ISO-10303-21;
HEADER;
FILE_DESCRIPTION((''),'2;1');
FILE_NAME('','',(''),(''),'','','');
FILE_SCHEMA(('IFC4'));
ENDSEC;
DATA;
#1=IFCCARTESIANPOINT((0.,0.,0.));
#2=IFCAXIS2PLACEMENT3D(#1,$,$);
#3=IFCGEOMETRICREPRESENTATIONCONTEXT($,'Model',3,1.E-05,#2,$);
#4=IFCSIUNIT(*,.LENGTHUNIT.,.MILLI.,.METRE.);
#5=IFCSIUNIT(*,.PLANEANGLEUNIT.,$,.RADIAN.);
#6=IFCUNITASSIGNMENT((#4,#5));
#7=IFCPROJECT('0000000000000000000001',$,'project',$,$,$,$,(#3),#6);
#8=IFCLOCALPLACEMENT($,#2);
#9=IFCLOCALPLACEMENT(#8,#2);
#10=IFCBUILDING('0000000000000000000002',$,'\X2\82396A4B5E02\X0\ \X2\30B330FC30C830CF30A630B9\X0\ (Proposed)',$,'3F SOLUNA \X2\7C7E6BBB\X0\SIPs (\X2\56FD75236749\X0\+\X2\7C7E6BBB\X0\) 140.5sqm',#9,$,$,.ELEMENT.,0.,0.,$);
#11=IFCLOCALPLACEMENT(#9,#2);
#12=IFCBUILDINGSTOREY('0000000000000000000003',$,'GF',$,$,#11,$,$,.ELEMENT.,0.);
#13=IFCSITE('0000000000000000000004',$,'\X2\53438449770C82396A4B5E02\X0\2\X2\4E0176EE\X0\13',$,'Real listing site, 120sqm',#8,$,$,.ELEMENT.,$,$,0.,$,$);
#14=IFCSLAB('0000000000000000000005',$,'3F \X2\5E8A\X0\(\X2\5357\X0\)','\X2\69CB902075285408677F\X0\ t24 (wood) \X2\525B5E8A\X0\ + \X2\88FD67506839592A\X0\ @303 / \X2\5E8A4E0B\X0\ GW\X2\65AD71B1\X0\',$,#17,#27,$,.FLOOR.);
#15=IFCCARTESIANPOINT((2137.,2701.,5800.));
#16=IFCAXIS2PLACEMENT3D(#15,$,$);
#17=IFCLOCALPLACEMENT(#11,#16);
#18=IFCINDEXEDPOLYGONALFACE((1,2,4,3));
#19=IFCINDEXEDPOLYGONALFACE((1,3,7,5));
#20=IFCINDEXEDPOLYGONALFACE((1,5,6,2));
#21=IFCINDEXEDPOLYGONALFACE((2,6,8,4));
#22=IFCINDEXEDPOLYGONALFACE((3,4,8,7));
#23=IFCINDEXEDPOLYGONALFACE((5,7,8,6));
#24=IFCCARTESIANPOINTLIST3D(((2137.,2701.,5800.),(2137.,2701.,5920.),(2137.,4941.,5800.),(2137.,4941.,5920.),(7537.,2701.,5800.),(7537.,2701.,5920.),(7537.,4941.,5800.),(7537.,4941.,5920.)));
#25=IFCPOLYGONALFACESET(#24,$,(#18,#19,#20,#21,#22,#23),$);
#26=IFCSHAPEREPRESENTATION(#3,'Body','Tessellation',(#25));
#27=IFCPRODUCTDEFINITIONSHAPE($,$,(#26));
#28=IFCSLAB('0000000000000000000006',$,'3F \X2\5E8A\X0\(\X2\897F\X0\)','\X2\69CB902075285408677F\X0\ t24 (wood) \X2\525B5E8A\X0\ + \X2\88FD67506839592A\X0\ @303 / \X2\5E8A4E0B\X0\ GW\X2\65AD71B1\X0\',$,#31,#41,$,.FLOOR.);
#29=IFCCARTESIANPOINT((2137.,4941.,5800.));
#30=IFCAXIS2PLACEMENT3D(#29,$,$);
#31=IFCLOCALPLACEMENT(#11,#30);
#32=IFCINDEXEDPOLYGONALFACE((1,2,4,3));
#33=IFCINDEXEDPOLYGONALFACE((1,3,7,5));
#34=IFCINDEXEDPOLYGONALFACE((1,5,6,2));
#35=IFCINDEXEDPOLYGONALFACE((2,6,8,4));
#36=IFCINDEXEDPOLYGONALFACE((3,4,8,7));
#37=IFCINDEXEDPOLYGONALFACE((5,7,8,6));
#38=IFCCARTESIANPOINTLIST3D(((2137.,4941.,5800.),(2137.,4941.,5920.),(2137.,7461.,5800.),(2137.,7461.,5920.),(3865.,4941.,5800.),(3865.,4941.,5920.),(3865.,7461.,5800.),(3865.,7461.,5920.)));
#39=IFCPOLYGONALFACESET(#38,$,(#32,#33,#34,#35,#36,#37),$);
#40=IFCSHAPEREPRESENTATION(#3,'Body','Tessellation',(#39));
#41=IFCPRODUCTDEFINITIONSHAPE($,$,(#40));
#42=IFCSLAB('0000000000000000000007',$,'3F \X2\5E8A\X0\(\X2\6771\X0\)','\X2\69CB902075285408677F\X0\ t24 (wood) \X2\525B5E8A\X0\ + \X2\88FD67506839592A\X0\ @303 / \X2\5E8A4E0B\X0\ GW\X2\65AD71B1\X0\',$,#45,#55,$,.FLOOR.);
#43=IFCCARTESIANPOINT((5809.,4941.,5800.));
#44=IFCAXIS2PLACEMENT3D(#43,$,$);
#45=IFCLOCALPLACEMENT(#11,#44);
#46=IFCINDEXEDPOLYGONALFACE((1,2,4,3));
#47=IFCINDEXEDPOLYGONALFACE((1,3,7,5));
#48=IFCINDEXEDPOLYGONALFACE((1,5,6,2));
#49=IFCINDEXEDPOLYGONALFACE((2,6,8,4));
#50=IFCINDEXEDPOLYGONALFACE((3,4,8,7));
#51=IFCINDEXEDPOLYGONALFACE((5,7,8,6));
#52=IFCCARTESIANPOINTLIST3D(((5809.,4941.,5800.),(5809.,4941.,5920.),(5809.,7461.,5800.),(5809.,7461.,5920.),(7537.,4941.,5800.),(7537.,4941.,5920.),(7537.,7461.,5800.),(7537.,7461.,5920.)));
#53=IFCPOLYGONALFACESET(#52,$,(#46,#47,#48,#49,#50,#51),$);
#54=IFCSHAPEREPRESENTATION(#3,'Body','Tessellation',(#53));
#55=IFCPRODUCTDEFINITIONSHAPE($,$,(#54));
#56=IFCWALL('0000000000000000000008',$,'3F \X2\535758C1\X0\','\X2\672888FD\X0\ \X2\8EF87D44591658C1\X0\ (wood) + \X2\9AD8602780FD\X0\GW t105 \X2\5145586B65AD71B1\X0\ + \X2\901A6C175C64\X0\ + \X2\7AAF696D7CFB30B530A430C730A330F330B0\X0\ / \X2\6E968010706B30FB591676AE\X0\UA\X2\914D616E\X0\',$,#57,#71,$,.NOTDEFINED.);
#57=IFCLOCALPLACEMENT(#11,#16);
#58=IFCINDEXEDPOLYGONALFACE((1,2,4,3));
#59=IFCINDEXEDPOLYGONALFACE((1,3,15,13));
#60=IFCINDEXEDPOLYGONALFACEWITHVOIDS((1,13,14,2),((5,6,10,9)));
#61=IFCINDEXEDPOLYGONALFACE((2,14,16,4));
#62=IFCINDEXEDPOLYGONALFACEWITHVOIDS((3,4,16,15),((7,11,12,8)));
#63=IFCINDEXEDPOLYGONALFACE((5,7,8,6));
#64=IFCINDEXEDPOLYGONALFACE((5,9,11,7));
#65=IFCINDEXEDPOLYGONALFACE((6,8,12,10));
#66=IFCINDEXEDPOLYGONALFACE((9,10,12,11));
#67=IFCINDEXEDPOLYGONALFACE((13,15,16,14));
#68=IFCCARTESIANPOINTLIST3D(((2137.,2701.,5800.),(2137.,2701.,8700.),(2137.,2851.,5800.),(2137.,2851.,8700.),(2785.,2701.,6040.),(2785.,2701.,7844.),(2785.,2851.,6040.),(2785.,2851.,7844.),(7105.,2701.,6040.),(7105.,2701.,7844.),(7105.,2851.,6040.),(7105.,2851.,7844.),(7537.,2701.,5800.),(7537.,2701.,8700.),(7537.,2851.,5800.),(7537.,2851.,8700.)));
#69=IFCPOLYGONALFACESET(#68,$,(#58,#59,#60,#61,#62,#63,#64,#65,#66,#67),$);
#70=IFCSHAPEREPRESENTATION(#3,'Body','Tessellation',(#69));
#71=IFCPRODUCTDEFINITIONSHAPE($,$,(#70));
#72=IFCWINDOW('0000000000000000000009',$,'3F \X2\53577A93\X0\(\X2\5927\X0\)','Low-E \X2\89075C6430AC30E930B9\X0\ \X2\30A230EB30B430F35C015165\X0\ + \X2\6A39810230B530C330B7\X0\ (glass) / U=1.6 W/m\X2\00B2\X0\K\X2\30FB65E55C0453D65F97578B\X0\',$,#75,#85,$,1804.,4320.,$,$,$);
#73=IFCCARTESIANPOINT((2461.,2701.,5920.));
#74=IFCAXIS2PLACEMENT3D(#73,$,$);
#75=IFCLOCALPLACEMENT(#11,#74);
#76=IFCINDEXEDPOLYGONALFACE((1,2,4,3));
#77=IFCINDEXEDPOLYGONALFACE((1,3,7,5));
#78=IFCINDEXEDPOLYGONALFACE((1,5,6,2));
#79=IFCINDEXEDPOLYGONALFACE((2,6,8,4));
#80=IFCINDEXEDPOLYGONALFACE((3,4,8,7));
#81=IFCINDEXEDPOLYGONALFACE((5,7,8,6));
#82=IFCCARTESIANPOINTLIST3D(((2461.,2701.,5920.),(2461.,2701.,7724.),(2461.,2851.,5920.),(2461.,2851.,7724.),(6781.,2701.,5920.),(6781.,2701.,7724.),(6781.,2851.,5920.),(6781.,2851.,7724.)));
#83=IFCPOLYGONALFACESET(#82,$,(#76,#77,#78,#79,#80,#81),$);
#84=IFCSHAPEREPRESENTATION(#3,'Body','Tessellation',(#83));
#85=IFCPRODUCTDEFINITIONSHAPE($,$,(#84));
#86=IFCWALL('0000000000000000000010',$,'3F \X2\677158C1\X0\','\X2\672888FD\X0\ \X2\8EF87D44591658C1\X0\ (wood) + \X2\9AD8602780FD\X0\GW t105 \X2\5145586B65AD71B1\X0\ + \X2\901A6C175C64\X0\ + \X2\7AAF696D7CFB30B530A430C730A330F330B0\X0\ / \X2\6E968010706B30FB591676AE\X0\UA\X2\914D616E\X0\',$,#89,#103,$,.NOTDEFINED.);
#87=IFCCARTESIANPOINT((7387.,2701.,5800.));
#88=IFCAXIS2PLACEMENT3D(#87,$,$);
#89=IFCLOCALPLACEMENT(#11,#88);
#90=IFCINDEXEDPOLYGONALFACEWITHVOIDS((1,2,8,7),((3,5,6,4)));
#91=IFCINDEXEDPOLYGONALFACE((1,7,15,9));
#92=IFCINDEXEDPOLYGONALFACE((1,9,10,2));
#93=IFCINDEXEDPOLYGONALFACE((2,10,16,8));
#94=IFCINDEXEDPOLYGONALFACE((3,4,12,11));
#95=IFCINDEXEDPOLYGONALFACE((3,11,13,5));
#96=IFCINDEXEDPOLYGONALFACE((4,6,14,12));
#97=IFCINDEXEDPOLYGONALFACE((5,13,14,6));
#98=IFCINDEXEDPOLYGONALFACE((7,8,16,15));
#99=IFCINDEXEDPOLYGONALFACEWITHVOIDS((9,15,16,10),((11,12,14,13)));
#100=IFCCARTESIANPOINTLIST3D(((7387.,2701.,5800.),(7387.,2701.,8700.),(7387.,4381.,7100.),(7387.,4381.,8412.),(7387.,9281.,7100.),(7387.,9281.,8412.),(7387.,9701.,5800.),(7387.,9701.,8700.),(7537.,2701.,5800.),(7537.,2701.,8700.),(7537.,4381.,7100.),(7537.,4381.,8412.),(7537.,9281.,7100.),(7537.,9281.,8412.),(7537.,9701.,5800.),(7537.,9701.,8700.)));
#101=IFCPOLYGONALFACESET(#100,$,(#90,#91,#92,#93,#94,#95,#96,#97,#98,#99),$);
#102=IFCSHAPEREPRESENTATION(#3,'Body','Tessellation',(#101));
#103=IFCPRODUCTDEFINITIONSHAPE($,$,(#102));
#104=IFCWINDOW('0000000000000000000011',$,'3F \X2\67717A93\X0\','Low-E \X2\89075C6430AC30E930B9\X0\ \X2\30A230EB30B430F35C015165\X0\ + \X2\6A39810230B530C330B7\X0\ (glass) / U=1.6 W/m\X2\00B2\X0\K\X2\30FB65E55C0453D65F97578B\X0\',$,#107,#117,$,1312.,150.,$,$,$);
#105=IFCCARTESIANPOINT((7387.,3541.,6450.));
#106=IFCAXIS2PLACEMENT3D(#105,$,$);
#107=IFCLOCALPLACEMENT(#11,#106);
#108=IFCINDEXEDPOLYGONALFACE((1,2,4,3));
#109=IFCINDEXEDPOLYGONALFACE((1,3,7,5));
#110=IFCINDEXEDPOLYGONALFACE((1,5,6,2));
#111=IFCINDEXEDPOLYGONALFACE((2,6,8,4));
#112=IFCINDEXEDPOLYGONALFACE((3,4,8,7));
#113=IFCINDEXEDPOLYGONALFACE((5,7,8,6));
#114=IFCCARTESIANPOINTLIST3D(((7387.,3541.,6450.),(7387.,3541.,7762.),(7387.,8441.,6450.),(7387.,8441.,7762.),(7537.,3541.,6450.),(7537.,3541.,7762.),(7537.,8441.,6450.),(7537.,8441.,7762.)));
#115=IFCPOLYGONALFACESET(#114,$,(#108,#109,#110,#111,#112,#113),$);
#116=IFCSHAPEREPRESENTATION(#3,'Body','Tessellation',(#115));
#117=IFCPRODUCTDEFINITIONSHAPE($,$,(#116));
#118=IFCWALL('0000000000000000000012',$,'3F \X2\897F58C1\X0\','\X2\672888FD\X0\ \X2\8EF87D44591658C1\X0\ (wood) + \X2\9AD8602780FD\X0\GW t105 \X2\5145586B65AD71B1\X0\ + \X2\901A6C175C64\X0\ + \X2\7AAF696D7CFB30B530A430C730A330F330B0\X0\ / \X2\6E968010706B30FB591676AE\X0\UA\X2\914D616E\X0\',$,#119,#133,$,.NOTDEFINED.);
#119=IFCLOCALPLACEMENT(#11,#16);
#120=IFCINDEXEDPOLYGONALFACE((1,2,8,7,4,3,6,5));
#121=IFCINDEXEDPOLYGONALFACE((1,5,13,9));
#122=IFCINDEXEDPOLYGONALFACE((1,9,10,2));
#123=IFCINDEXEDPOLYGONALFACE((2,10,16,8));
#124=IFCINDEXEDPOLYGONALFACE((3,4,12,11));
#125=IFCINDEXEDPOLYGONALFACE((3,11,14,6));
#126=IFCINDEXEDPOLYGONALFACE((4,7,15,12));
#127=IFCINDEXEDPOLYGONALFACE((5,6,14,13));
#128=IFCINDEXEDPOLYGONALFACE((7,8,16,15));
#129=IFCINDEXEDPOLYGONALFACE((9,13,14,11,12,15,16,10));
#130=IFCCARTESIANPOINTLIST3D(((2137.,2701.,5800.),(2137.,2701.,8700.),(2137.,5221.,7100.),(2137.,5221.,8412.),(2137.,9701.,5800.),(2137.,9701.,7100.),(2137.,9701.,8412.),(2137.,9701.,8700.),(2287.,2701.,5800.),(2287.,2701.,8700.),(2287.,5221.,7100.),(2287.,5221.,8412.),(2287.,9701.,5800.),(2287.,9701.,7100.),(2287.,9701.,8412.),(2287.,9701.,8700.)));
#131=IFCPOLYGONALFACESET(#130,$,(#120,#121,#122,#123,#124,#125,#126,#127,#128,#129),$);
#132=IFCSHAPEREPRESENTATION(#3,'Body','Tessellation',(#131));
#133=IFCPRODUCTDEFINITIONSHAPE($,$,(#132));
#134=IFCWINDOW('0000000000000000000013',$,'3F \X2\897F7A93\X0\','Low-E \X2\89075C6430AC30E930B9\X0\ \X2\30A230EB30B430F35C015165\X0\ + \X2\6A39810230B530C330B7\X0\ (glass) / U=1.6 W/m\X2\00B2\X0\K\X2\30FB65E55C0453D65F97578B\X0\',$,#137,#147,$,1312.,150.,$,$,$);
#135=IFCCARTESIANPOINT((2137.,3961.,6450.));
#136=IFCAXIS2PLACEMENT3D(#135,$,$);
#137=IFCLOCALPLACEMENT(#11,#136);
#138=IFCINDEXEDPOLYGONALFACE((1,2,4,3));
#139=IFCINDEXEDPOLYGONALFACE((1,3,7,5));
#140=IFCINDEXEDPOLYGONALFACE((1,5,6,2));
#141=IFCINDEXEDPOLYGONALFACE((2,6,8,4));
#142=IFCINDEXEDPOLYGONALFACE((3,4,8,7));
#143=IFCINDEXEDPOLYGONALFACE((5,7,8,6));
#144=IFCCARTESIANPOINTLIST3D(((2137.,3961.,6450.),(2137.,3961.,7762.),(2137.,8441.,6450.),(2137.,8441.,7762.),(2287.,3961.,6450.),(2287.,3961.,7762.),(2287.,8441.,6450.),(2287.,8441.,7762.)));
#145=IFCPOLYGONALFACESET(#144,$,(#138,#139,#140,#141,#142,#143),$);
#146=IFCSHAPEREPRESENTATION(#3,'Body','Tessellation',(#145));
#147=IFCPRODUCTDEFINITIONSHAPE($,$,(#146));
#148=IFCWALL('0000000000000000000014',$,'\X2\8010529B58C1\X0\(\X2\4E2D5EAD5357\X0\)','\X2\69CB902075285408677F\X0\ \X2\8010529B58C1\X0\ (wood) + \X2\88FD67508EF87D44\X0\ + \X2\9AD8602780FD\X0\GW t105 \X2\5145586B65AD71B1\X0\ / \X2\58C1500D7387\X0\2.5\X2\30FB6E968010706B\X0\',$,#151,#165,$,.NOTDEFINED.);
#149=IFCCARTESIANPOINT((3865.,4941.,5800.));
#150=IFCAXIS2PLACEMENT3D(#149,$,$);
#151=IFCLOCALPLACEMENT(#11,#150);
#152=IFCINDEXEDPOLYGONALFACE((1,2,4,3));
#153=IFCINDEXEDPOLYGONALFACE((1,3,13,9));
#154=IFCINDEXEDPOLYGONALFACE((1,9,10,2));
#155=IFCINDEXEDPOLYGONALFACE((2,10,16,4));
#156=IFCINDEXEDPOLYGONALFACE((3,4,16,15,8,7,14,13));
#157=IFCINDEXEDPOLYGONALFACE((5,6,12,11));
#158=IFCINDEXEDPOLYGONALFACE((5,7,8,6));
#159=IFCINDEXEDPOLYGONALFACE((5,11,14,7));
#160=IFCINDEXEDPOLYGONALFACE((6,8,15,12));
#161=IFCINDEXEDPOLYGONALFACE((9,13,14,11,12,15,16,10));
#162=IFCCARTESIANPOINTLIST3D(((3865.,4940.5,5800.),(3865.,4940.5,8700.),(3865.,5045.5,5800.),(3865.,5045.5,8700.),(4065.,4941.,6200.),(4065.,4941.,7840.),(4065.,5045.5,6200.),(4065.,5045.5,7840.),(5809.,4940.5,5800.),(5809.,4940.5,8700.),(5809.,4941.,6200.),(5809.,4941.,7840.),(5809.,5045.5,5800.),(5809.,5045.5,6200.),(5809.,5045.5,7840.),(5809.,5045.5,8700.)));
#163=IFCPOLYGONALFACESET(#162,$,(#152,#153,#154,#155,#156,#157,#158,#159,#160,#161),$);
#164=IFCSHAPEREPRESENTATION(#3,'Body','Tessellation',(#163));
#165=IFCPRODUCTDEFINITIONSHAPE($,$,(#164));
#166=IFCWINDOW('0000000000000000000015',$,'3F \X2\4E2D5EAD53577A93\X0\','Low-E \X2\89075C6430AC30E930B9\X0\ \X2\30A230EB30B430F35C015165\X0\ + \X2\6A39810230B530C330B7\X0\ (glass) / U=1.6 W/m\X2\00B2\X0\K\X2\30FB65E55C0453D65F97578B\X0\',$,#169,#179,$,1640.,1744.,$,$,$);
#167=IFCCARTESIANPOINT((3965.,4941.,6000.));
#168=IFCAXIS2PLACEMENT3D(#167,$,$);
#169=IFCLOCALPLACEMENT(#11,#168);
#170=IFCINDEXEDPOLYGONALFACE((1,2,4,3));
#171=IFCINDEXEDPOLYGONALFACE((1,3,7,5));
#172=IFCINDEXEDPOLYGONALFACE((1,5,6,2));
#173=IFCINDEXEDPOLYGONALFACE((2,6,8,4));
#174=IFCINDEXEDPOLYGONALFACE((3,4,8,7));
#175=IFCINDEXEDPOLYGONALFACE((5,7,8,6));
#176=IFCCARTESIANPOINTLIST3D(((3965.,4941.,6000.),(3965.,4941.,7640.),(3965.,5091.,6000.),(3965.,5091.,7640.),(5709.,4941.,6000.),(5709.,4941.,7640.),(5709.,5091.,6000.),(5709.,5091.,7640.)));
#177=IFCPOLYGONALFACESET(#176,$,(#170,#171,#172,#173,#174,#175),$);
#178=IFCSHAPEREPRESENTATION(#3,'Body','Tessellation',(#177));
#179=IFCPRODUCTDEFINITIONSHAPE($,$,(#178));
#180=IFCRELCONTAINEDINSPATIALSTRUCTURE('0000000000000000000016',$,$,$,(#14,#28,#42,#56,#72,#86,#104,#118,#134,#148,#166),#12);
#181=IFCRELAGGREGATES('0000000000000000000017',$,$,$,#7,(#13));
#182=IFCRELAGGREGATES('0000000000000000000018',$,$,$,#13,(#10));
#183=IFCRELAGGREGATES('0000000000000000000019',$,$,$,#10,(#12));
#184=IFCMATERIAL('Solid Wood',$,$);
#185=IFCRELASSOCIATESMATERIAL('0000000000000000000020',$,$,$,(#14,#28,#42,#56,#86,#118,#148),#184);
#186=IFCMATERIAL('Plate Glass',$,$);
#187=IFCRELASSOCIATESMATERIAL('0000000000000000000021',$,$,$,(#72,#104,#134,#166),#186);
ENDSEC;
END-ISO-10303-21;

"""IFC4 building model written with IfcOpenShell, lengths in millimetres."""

from ifc_helpers import new_model, si_unit, frame, frame_2d, origin, place, context, project, spatial, rectangle, extrude, material, element, fill, save


model = new_model("IFC4")

# Units and contexts
model_context = context("Model", 3, precision=1e-05, world=origin())
ifc_project = project(units=[si_unit("LENGTHUNIT", "METRE", prefix="MILLI"), si_unit("PLANEANGLEUNIT", "RADIAN")], contexts=[model_context])

# Site, building, storey
site_placement = place(None, origin())
site = spatial("IfcSite", under=ifc_project, at=site_placement, Name="千葉県船橋市2丁目13", ObjectType="Real listing site, 120sqm", CompositionType="ELEMENT", RefElevation=0.0)
building_placement = place(site_placement, origin())
building = spatial("IfcBuilding", under=site, at=building_placement, Name="船橋市 コートハウス (Proposed)", ObjectType="3F SOLUNA 籾殻SIPs (国産杉+籾殻) 140.5sqm", CompositionType="ELEMENT", ElevationOfRefHeight=0.0, ElevationOfTerrain=0.0)
storey_placement = place(building_placement, origin())
storey = spatial("IfcBuildingStorey", under=building, at=storey_placement, Name="GF", CompositionType="ELEMENT", Elevation=0.0)

# Slabs
ifc_material_1 = material(Name="Solid Wood")
slab_1_placement = place(storey_placement, frame((2137.0, 2701.0, 5800.0)))
element("IfcSlab", 1, at=slab_1_placement, inside=storey, material=ifc_material_1, Name="3F 床(南)", Description="構造用合板 t24 (wood) 剛床 + 製材根太 @303 / 床下 GW断熱", PredefinedType="FLOOR", context=model_context, shape_type="SweptSolid", body=[
    extrude(rectangle(XDim=5400.0, YDim=2240.0, at=frame_2d((2700.0, 1120.0))), frame((2137.0, 2701.0, 5800.0)), (0.0, 0.0, 1.0), 120.0),
])
slab_2_placement = place(storey_placement, frame((2137.0, 4941.0, 5800.0)))
element("IfcSlab", 2, at=slab_2_placement, inside=storey, material=ifc_material_1, Name="3F 床(西)", Description="構造用合板 t24 (wood) 剛床 + 製材根太 @303 / 床下 GW断熱", PredefinedType="FLOOR", context=model_context, shape_type="SweptSolid", body=[
    extrude(rectangle(XDim=1728.0, YDim=2520.0, at=frame_2d((864.0, 1260.0))), frame((2137.0, 4941.0, 5800.0)), (0.0, 0.0, 1.0), 120.0),
])
slab_3_placement = place(storey_placement, frame((5809.0, 4941.0, 5800.0)))
element("IfcSlab", 3, at=slab_3_placement, inside=storey, material=ifc_material_1, Name="3F 床(東)", Description="構造用合板 t24 (wood) 剛床 + 製材根太 @303 / 床下 GW断熱", PredefinedType="FLOOR", context=model_context, shape_type="SweptSolid", body=[
    extrude(rectangle(XDim=1728.0, YDim=2520.0, at=frame_2d((864.0, 1260.0))), frame((5809.0, 4941.0, 5800.0)), (0.0, 0.0, 1.0), 120.0),
])

# Walls, openings, windows
wall_1_placement = place(storey_placement, frame((2137.0, 2701.0, 5800.0)))
wall_1 = element("IfcWall", 4, at=wall_1_placement, inside=storey, material=ifc_material_1, Name="3F 南壁", Description="木製 軸組外壁 (wood) + 高性能GW t105 充填断熱 + 通気層 + 窯業系サイディング / 準耐火・外皮UA配慮", PredefinedType="NOTDEFINED", context=model_context, shape_type="SweptSolid", body=[
    extrude(rectangle(XDim=5400.0, YDim=150.0, at=frame_2d((2700.0, 75.0))), frame((2137.0, 2701.0, 5800.0)), (0.0, 0.0, 1.0), 2900.0),
])
opening_1_placement = place(storey_placement, frame((2461.0, 2701.0, 5920.0)))
opening_1 = element("IfcOpeningElement", 5, at=opening_1_placement, cuts=wall_1, PredefinedType="NOTDEFINED", context=model_context, shape_type="SweptSolid", body=[
    extrude(rectangle(XDim=4320.0, YDim=150.0, at=frame_2d((2160.0, 75.0))), frame((2461.0, 2701.0, 5920.0)), (0.0, 0.0, 1.0), 1804.0),
])
ifc_material_2 = material(Name="Plate Glass")
window_1_placement = place(storey_placement, frame((2461.0, 2701.0, 5920.0)))
window_1 = element("IfcWindow", 6, at=window_1_placement, inside=storey, material=ifc_material_2, Name="3F 南窓(大)", Description="Low-E 複層ガラス アルゴン封入 + 樹脂サッシ (glass) / U=1.6 W/m²K・日射取得型", OverallHeight=1804.0, OverallWidth=4320.0, context=model_context, shape_type="SweptSolid", body=[
    extrude(rectangle(XDim=4320.0, YDim=150.0, at=frame_2d((2160.0, 75.0))), frame((2461.0, 2701.0, 5920.0)), (0.0, 0.0, 1.0), 1804.0),
])
fill(opening_1, window_1)
wall_2_placement = place(storey_placement, frame((7387.0, 2701.0, 5800.0)))
wall_2 = element("IfcWall", 7, at=wall_2_placement, inside=storey, material=ifc_material_1, Name="3F 東壁", Description="木製 軸組外壁 (wood) + 高性能GW t105 充填断熱 + 通気層 + 窯業系サイディング / 準耐火・外皮UA配慮", PredefinedType="NOTDEFINED", context=model_context, shape_type="SweptSolid", body=[
    extrude(rectangle(XDim=150.0, YDim=7000.0, at=frame_2d((75.0, 3500.0))), frame((7387.0, 2701.0, 5800.0)), (0.0, 0.0, 1.0), 2900.0),
])
opening_2_placement = place(storey_placement, frame((7387.0, 3541.0, 6450.0)))
opening_2 = element("IfcOpeningElement", 8, at=opening_2_placement, cuts=wall_2, PredefinedType="NOTDEFINED", context=model_context, shape_type="SweptSolid", body=[
    extrude(rectangle(XDim=150.0, YDim=4900.0, at=frame_2d((75.0, 2450.0))), frame((7387.0, 3541.0, 6450.0)), (0.0, 0.0, 1.0), 1312.0),
])
window_2_placement = place(storey_placement, frame((7387.0, 3541.0, 6450.0)))
window_2 = element("IfcWindow", 9, at=window_2_placement, inside=storey, material=ifc_material_2, Name="3F 東窓", Description="Low-E 複層ガラス アルゴン封入 + 樹脂サッシ (glass) / U=1.6 W/m²K・日射取得型", OverallHeight=1312.0, OverallWidth=150.0, context=model_context, shape_type="SweptSolid", body=[
    extrude(rectangle(XDim=150.0, YDim=4900.0, at=frame_2d((75.0, 2450.0))), frame((7387.0, 3541.0, 6450.0)), (0.0, 0.0, 1.0), 1312.0),
])
fill(opening_2, window_2)
wall_3_placement = place(storey_placement, frame((2137.0, 2701.0, 5800.0)))
wall_3 = element("IfcWall", 10, at=wall_3_placement, inside=storey, material=ifc_material_1, Name="3F 西壁", Description="木製 軸組外壁 (wood) + 高性能GW t105 充填断熱 + 通気層 + 窯業系サイディング / 準耐火・外皮UA配慮", PredefinedType="NOTDEFINED", context=model_context, shape_type="SweptSolid", body=[
    extrude(rectangle(XDim=150.0, YDim=7000.0, at=frame_2d((75.0, 3500.0))), frame((2137.0, 2701.0, 5800.0)), (0.0, 0.0, 1.0), 2900.0),
])
opening_3_placement = place(storey_placement, frame((2137.0, 3961.0, 6450.0)))
opening_3 = element("IfcOpeningElement", 11, at=opening_3_placement, cuts=wall_3, PredefinedType="NOTDEFINED", context=model_context, shape_type="SweptSolid", body=[
    extrude(rectangle(XDim=150.0, YDim=4480.0, at=frame_2d((75.0, 2240.0))), frame((2137.0, 3961.0, 6450.0)), (0.0, 0.0, 1.0), 1312.0),
])
window_3_placement = place(storey_placement, frame((2137.0, 3961.0, 6450.0)))
window_3 = element("IfcWindow", 12, at=window_3_placement, inside=storey, material=ifc_material_2, Name="3F 西窓", Description="Low-E 複層ガラス アルゴン封入 + 樹脂サッシ (glass) / U=1.6 W/m²K・日射取得型", OverallHeight=1312.0, OverallWidth=150.0, context=model_context, shape_type="SweptSolid", body=[
    extrude(rectangle(XDim=150.0, YDim=4480.0, at=frame_2d((75.0, 2240.0))), frame((2137.0, 3961.0, 6450.0)), (0.0, 0.0, 1.0), 1312.0),
])
fill(opening_3, window_3)
wall_4_placement = place(storey_placement, frame((3865.0, 4941.0, 5800.0)))
wall_4 = element("IfcWall", 13, at=wall_4_placement, inside=storey, material=ifc_material_1, Name="耐力壁(中庭南)", Description="構造用合板 耐力壁 (wood) + 製材軸組 + 高性能GW t105 充填断熱 / 壁倍率2.5・準耐火", PredefinedType="NOTDEFINED", context=model_context, shape_type="SweptSolid", body=[
    extrude(rectangle(XDim=1944.0, YDim=105.0, at=frame_2d((972.0, 52.0))), frame((3865.0, 4941.0, 5800.0)), (0.0, 0.0, 1.0), 2900.0),
])
opening_4_placement = place(storey_placement, frame((3965.0, 4941.0, 6000.0)))
opening_4 = element("IfcOpeningElement", 14, at=opening_4_placement, cuts=wall_4, PredefinedType="NOTDEFINED", context=model_context, shape_type="SweptSolid", body=[
    extrude(rectangle(XDim=1744.0, YDim=150.0, at=frame_2d((872.0, 75.0))), frame((3965.0, 4941.0, 6000.0)), (0.0, 0.0, 1.0), 1640.0),
])
window_4_placement = place(storey_placement, frame((3965.0, 4941.0, 6000.0)))
window_4 = element("IfcWindow", 15, at=window_4_placement, inside=storey, material=ifc_material_2, Name="3F 中庭南窓", Description="Low-E 複層ガラス アルゴン封入 + 樹脂サッシ (glass) / U=1.6 W/m²K・日射取得型", OverallHeight=1640.0, OverallWidth=1744.0, context=model_context, shape_type="SweptSolid", body=[
    extrude(rectangle(XDim=1744.0, YDim=150.0, at=frame_2d((872.0, 75.0))), frame((3965.0, 4941.0, 6000.0)), (0.0, 0.0, 1.0), 1640.0),
])
fill(opening_4, window_4)

save(model, "model.ifc")
